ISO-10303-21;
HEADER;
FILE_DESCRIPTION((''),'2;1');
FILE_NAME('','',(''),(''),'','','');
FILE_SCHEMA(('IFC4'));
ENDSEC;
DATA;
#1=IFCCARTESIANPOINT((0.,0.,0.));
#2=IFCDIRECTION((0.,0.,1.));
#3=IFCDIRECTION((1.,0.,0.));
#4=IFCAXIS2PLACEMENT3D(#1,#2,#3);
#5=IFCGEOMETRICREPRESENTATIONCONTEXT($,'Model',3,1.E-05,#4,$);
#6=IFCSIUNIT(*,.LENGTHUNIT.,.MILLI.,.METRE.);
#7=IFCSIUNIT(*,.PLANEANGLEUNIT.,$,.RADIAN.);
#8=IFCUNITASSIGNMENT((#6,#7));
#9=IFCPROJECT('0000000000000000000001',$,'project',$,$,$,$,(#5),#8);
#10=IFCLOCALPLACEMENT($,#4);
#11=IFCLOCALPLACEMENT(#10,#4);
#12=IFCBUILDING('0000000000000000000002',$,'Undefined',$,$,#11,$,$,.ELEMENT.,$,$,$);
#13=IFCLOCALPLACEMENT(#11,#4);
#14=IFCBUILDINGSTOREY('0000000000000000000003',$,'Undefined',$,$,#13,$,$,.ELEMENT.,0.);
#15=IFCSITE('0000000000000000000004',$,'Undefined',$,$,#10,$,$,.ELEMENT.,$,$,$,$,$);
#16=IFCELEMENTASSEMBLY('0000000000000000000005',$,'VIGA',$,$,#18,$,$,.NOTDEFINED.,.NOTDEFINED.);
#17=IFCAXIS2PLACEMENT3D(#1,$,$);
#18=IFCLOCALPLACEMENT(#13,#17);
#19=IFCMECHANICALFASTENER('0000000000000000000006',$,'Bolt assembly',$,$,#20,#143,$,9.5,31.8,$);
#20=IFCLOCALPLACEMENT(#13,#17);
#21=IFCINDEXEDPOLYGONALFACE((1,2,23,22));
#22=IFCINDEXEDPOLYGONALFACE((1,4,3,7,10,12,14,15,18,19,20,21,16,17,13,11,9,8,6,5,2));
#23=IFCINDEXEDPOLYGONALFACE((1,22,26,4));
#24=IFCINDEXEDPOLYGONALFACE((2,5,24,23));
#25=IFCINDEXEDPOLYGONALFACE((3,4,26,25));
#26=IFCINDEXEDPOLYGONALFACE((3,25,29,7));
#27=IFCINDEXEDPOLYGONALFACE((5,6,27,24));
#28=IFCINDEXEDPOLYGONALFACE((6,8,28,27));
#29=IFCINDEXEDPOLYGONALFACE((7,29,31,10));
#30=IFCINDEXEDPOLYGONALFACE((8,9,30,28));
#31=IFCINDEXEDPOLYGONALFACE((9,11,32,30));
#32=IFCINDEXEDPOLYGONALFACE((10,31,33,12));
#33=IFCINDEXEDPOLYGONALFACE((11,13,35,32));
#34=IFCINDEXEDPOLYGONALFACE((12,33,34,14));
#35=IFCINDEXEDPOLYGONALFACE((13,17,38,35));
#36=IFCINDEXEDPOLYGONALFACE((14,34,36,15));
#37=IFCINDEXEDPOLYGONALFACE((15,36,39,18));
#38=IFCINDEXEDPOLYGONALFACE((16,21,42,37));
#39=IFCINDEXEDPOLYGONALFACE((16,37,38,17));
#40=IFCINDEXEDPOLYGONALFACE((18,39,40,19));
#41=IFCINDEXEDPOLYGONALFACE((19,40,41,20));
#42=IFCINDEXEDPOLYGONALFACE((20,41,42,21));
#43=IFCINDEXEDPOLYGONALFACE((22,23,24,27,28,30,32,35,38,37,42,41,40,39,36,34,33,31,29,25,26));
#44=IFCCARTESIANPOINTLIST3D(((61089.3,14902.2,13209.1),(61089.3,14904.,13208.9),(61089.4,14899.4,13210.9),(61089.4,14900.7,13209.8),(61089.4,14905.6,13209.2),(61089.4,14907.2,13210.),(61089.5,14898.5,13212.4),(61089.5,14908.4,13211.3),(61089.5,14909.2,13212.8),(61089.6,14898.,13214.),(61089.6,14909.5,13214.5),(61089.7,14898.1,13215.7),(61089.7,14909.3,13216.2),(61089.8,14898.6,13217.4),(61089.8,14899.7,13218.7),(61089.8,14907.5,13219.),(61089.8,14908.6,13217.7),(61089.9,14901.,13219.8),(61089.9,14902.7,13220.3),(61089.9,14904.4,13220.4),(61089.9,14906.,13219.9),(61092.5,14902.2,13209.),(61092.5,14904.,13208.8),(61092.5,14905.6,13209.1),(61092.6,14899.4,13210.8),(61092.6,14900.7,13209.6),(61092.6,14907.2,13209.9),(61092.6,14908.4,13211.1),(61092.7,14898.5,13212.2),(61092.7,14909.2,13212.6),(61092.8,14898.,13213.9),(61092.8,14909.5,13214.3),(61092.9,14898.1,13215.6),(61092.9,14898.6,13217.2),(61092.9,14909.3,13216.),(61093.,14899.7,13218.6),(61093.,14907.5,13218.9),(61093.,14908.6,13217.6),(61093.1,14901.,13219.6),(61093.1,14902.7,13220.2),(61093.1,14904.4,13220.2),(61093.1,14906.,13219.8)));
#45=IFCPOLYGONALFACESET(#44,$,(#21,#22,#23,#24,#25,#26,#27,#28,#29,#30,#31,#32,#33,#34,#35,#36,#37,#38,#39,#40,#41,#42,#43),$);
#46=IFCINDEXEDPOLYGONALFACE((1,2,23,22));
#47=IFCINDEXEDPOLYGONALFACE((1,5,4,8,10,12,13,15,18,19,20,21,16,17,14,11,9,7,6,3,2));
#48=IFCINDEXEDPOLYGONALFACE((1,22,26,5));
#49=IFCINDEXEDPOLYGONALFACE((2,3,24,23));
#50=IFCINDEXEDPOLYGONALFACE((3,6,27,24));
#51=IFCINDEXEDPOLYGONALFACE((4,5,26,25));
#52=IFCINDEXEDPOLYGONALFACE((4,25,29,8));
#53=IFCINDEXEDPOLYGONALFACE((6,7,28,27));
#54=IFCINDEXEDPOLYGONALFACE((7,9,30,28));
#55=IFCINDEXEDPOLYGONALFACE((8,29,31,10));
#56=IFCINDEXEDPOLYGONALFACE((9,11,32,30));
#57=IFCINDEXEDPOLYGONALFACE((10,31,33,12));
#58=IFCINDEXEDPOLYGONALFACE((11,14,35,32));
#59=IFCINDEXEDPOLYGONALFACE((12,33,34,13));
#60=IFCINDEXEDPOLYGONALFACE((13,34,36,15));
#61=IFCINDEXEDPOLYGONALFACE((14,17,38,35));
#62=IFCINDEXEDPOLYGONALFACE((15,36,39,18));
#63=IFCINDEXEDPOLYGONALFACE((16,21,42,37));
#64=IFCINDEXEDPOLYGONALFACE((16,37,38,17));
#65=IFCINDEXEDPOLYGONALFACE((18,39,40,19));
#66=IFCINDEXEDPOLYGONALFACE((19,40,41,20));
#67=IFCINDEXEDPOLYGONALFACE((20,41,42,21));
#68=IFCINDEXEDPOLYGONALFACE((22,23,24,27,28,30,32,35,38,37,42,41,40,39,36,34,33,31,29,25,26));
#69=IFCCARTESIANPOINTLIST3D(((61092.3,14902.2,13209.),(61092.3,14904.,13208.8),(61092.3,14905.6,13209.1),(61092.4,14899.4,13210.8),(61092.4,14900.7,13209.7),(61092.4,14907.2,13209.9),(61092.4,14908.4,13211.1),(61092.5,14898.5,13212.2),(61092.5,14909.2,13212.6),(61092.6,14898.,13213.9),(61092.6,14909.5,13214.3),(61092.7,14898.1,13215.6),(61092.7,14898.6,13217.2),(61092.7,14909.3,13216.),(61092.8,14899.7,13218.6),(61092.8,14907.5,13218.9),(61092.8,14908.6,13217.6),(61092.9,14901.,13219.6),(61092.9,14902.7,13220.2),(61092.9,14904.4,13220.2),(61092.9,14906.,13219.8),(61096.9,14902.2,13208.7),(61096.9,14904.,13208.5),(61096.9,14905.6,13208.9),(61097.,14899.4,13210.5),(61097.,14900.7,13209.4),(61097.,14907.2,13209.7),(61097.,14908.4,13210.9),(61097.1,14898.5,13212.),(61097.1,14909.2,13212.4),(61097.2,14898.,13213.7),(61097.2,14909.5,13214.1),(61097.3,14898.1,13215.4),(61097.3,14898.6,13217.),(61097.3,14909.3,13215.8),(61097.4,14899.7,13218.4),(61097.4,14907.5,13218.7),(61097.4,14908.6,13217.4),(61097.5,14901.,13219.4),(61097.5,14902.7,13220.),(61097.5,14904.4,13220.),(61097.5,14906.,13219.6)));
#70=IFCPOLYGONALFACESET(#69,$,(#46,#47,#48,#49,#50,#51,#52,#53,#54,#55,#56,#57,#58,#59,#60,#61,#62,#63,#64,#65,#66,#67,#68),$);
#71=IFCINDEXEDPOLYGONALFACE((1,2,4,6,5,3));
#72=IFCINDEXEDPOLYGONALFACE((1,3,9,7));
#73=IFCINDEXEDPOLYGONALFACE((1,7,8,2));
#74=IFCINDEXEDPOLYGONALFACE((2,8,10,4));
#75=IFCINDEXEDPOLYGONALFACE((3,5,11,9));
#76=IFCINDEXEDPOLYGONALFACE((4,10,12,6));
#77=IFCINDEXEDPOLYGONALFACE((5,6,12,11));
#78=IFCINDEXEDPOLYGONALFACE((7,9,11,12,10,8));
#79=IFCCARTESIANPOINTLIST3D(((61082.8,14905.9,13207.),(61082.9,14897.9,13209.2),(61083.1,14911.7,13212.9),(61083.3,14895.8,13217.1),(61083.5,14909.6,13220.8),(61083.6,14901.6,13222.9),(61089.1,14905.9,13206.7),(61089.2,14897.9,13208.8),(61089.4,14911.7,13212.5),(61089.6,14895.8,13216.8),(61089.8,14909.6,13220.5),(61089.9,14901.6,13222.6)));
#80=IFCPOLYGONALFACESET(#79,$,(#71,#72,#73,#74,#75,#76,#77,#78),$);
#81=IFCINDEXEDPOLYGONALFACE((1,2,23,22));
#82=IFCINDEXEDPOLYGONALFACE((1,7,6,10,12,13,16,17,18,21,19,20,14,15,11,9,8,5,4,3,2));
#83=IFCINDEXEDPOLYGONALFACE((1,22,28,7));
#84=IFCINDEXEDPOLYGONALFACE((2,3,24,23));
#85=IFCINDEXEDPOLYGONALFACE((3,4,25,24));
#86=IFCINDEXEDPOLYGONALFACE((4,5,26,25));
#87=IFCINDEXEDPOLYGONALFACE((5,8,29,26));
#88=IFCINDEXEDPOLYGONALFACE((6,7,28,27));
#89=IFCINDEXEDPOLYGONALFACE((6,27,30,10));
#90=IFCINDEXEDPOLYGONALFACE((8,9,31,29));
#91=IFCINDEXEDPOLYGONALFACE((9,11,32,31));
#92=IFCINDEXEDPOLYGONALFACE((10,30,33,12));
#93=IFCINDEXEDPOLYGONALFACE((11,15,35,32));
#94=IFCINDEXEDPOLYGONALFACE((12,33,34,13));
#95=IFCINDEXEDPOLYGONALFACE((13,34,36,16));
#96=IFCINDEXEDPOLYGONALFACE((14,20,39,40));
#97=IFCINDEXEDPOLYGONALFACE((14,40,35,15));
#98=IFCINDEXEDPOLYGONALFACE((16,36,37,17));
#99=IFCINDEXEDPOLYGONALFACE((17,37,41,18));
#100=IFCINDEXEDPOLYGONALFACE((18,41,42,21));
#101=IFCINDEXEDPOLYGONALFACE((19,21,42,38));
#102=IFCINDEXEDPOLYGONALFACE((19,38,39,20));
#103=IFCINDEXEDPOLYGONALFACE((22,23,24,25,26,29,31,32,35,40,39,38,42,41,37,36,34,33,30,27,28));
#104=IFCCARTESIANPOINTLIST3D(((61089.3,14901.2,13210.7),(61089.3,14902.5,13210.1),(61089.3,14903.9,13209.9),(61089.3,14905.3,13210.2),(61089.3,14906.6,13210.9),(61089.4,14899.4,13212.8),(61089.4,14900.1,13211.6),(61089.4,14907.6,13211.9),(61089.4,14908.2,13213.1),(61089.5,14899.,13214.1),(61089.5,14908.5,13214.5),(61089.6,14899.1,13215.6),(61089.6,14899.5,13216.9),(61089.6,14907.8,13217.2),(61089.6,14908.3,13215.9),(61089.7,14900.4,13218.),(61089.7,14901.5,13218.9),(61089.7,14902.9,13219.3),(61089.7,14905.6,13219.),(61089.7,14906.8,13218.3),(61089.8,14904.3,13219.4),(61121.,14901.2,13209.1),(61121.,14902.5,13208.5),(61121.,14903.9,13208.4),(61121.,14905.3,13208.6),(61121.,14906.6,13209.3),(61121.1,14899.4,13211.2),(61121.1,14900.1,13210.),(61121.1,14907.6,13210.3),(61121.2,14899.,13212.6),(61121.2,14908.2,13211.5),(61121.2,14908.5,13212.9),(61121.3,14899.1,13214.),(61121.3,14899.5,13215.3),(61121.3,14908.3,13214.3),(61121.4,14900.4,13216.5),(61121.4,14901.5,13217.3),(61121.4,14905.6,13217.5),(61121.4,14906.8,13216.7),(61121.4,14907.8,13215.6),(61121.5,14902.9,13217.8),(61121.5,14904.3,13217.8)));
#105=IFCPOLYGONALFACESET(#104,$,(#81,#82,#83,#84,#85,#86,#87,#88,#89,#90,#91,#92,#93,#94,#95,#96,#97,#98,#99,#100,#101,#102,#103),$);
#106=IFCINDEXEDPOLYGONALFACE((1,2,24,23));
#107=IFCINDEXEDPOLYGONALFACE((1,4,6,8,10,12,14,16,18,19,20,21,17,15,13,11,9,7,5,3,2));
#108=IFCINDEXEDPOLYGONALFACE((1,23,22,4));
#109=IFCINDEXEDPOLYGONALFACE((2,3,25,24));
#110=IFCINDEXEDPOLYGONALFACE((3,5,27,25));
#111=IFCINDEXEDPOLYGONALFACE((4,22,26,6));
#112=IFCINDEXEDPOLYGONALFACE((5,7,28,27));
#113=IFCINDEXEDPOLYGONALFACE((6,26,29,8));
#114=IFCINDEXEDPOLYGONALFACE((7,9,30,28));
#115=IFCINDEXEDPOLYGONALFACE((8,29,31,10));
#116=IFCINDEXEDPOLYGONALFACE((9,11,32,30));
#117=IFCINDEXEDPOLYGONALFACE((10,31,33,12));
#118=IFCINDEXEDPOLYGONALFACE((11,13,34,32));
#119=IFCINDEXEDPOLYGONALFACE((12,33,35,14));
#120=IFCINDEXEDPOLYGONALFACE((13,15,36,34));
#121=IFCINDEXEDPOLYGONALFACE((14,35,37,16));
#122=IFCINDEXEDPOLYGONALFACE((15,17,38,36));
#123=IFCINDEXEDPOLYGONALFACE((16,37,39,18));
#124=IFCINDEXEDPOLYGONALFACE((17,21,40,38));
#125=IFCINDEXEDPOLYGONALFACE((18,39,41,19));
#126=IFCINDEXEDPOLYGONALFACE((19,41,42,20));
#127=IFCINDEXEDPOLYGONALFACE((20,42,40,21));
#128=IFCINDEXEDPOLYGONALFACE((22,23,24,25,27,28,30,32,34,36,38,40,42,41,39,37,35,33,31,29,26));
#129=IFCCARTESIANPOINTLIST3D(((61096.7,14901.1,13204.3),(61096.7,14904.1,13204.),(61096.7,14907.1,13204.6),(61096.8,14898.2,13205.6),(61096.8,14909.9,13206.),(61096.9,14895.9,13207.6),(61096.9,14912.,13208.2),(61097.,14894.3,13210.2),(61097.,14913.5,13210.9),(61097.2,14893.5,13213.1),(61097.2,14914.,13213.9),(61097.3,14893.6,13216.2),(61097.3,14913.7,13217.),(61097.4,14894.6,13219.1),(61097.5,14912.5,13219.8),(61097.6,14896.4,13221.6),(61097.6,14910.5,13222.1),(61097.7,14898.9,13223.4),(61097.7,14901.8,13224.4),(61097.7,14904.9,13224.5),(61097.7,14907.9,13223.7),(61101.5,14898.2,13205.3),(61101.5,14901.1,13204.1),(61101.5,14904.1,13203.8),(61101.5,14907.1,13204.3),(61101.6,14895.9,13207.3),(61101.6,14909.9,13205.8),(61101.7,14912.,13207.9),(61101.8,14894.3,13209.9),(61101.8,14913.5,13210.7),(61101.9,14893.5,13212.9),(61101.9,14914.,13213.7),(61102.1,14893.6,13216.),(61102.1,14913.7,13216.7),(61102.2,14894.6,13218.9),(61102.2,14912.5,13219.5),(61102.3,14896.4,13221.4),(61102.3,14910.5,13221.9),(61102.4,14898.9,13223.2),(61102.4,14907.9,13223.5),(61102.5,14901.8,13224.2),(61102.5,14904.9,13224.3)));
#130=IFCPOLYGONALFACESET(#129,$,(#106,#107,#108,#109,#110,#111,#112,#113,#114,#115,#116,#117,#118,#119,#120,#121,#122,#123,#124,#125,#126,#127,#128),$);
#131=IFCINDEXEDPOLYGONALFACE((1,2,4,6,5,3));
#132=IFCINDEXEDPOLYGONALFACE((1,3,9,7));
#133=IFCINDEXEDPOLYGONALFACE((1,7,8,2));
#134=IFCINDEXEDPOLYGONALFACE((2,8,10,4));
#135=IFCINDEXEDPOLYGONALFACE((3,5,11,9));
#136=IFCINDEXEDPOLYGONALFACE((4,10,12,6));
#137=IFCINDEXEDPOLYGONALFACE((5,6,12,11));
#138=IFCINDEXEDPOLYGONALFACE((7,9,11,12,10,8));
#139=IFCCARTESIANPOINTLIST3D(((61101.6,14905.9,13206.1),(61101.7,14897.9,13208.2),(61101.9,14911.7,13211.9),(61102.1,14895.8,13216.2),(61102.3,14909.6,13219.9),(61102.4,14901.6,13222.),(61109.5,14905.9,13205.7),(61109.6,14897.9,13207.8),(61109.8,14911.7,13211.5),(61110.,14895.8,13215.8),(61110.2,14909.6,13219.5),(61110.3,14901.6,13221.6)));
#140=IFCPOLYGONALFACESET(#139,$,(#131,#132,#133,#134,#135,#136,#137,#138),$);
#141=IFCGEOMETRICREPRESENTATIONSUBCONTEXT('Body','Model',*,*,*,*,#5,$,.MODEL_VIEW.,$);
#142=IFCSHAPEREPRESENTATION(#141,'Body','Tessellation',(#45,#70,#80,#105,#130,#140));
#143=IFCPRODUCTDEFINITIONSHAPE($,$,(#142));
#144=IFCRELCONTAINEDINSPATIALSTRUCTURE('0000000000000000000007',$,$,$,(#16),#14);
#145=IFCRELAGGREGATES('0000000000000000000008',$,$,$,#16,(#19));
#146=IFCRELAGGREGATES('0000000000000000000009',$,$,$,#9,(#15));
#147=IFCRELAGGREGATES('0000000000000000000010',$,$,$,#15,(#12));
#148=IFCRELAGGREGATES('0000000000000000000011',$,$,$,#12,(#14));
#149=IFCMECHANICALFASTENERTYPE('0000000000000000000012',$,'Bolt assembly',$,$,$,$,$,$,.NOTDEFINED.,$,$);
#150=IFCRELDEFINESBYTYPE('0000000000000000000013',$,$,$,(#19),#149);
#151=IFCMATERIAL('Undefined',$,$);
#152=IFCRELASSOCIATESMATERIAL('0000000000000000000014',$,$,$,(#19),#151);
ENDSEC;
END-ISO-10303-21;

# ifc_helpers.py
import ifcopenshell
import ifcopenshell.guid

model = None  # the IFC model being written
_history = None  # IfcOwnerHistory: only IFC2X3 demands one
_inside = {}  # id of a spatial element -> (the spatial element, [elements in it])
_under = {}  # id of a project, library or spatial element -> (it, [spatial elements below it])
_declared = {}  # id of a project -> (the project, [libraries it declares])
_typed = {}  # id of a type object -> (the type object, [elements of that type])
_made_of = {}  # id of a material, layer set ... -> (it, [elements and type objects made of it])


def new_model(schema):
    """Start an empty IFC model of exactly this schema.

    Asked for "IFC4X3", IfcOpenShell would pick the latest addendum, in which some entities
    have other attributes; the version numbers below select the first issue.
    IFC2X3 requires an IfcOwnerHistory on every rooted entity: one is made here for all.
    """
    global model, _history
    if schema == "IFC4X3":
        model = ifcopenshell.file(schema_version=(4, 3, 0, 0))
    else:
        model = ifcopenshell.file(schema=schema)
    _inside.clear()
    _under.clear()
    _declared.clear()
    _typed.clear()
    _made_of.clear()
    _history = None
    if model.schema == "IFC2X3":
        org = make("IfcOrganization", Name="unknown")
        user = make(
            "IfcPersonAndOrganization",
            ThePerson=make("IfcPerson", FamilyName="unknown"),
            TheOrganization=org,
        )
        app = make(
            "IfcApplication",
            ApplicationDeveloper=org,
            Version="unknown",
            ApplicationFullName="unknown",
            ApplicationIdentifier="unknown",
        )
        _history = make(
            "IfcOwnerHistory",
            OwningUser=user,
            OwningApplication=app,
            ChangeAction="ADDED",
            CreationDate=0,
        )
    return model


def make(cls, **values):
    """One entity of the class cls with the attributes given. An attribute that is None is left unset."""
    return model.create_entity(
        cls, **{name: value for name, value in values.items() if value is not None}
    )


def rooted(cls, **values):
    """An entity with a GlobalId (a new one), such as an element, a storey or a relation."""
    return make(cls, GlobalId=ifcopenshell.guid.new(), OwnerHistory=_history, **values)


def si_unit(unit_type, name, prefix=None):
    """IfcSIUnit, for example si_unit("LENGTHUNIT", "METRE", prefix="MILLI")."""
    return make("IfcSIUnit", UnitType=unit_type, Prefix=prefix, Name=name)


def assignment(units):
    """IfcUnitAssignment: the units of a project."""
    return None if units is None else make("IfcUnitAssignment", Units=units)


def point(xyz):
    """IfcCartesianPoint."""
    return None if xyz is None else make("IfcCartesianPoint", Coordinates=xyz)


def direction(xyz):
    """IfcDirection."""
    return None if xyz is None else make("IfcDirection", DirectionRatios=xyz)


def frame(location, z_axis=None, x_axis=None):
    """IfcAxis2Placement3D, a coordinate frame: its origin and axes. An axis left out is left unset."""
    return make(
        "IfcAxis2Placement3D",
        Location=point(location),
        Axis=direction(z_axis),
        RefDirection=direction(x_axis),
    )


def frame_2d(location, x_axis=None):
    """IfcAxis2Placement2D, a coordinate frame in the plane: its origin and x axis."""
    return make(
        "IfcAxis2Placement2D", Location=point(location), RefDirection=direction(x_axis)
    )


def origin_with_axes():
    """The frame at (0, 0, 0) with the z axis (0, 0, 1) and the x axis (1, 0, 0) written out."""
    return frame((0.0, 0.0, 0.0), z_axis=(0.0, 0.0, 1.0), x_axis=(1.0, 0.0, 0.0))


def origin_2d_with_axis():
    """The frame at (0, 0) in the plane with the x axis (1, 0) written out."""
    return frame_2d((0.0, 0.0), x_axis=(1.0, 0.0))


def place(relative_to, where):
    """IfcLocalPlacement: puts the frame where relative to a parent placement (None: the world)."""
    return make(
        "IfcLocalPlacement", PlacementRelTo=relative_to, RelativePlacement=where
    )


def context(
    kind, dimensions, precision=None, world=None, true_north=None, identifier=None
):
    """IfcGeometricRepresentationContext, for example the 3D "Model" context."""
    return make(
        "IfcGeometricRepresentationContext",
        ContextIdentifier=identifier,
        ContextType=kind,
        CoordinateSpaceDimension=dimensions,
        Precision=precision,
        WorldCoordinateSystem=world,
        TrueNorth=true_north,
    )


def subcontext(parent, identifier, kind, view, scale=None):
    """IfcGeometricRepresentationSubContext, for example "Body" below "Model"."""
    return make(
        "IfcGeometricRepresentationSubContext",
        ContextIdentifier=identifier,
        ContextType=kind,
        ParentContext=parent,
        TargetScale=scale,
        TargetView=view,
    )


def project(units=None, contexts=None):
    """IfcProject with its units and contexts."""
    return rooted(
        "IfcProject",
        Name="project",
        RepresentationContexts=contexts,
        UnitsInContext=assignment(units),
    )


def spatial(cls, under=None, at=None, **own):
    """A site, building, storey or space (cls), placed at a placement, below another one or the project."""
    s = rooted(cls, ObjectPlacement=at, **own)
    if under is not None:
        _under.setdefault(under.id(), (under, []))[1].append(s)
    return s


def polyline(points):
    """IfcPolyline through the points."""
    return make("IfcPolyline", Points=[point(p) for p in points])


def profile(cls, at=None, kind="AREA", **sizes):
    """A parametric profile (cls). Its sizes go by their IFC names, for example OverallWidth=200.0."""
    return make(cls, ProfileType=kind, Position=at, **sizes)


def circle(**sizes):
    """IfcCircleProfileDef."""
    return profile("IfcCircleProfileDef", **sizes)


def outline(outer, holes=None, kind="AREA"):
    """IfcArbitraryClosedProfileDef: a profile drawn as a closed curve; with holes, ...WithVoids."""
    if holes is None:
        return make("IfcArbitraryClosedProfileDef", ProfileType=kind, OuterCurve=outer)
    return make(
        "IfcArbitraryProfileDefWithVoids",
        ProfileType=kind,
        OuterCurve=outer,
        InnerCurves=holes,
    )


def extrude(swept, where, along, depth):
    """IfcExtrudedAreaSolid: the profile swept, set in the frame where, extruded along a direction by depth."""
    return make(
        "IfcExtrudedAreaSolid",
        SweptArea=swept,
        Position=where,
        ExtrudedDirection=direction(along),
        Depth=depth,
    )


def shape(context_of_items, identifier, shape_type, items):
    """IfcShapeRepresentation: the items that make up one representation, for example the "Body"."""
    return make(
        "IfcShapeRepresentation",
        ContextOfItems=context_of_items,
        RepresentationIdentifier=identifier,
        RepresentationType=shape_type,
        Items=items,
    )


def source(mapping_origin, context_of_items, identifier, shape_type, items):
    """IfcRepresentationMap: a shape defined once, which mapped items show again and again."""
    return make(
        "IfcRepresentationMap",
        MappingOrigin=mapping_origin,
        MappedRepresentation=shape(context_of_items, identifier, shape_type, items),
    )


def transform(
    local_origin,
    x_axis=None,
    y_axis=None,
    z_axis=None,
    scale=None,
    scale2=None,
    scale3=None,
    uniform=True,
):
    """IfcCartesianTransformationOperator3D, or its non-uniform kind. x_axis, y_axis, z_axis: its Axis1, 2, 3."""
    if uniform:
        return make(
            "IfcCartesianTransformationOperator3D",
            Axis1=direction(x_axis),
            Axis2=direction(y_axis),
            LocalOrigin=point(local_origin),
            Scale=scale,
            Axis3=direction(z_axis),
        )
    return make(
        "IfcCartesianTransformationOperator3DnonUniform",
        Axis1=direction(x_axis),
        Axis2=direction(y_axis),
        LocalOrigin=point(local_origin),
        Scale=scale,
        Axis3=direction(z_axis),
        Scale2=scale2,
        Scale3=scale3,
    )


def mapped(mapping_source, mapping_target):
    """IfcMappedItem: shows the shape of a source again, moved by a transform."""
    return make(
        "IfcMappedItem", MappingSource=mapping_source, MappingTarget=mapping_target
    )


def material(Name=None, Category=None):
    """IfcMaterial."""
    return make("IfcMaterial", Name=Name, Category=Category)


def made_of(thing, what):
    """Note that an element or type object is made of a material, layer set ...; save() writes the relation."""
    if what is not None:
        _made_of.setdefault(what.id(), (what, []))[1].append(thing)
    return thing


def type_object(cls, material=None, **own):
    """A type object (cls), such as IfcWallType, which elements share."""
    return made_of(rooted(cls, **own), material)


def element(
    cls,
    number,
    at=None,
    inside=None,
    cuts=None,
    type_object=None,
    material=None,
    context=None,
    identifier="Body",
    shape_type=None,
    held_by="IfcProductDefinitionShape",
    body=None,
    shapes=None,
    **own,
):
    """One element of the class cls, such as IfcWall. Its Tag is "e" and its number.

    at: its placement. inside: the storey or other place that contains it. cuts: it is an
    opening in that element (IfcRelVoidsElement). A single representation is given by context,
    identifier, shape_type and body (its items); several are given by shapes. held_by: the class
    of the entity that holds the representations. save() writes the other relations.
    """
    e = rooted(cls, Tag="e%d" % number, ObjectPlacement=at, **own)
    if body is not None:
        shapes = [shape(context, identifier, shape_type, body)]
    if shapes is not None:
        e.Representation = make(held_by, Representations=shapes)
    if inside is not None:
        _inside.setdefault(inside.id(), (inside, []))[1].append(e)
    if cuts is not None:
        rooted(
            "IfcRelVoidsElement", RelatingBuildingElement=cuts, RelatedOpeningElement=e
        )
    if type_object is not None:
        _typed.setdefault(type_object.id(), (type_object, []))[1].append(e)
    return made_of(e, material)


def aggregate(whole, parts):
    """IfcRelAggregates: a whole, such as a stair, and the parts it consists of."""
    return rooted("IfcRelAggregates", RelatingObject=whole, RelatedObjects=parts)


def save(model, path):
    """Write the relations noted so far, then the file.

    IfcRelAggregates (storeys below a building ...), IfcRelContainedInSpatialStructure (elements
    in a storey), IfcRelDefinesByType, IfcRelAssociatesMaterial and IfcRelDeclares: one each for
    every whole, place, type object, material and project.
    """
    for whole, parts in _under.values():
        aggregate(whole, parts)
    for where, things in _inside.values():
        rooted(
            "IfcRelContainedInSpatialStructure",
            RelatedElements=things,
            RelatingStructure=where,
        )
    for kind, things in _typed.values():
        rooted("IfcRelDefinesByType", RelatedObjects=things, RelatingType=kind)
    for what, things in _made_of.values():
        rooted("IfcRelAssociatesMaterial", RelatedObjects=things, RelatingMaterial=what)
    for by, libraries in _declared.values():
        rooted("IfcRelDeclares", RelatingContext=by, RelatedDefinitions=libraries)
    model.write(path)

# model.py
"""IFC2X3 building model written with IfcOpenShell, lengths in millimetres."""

from ifc_helpers import new_model, si_unit, frame, origin_with_axes, origin_2d_with_axis, place, context, subcontext, project, spatial, polyline, circle, outline, extrude, source, transform, mapped, material, type_object, element, aggregate, save


model = new_model("IFC2X3")

# Units and contexts
model_context = context("Model", 3, precision=1e-05, world=origin_with_axes())
body_context = subcontext(model_context, "Body", "Model", "MODEL_VIEW")
ifc_project = project(units=[si_unit("LENGTHUNIT", "METRE", prefix="MILLI"), si_unit("PLANEANGLEUNIT", "RADIAN")], contexts=[model_context])

# Site, building, storey
site_placement = place(None, origin_with_axes())
site = spatial("IfcSite", under=ifc_project, at=site_placement, Name="Undefined", CompositionType="ELEMENT")
building_placement = place(site_placement, origin_with_axes())
building = spatial("IfcBuilding", under=site, at=building_placement, Name="Undefined", CompositionType="ELEMENT")
storey_placement = place(building_placement, origin_with_axes())
storey = spatial("IfcBuildingStorey", under=building, at=storey_placement, Name="Undefined", CompositionType="ELEMENT", Elevation=0.0)

# Element assembly
assembly_1_placement = place(storey_placement, origin_with_axes())
assembly_1 = element("IfcElementAssembly", 1, at=assembly_1_placement, inside=storey, Name="VIGA", AssemblyPlace="NOTDEFINED", PredefinedType="NOTDEFINED")

# Shared definitions
mechanical_fastener_type = type_object("IfcMechanicalFastenerType", Name="Bolt assembly")

# Shared definitions
ifc_material_1 = material(Name="Undefined")

# Mechanical fastener
shared_shape_1 = source(origin_with_axes(), body_context, "Body", "SweptSolid", [
    extrude(circle(Radius=5.8, at=origin_2d_with_axis()), frame((0.0, -3.1, 0.0), z_axis=(0.0, 1.0, 0.0), x_axis=(1.0, 0.0, 0.0)), (0.0, 0.0, 1.0), 3.2),
    extrude(circle(Radius=5.8, at=origin_2d_with_axis()), frame((0.0, -0.1, 0.0), z_axis=(0.0, 1.0, 0.0), x_axis=(1.0, 0.0, 0.0)), (0.0, 0.0, 1.0), 4.6),
    extrude(outline(polyline([(7.1, -4.1), (7.1, 4.1), (0.0, 8.2), (-7.1, 4.1), (-7.1, -4.1), (0.0, -8.2), (7.1, -4.1)])), frame((0.0, -9.5, 0.0), z_axis=(0.0, 1.0, 0.0), x_axis=(1.0, 0.0, 0.0)), (0.0, 0.0, 1.0), 6.3),
    extrude(circle(Radius=4.8, at=origin_2d_with_axis()), frame((0.0, -3.2, 0.0), z_axis=(0.0, 1.0, 0.0), x_axis=(1.0, 0.0, 0.0)), (0.0, 0.0, 1.0), 31.8),
    extrude(circle(Radius=10.3, at=origin_2d_with_axis()), frame((0.0, 4.5, 0.0), z_axis=(0.0, 1.0, 0.0), x_axis=(1.0, 0.0, 0.0)), (0.0, 0.0, 1.0), 4.8),
    extrude(outline(polyline([(7.1, -4.1), (7.1, 4.1), (0.0, 8.2), (-7.1, 4.1), (-7.1, -4.1), (0.0, -8.2), (7.1, -4.1)])), frame((0.0, 9.3, 0.0), z_axis=(0.0, 1.0, 0.0), x_axis=(1.0, 0.0, 0.0)), (0.0, 0.0, 1.0), 7.9),
])
mechanical_fastener_1_placement = place(assembly_1_placement, frame((61092.7, 14903.7, 13214.5), z_axis=(0.034712, 0.707107, 0.706254), x_axis=(0.034712, -0.707107, 0.706254)))
mechanical_fastener_1 = element("IfcMechanicalFastener", 2, at=mechanical_fastener_1_placement, type_object=mechanical_fastener_type, material=ifc_material_1, Name="Bolt assembly", NominalDiameter=9.5, NominalLength=31.8, context=body_context, shape_type="MappedRepresentation", body=[
    mapped(shared_shape_1, transform((0.0, 0.0, 0.0))),
])
aggregate(assembly_1, [mechanical_fastener_1])

save(model, "model.ifc")
